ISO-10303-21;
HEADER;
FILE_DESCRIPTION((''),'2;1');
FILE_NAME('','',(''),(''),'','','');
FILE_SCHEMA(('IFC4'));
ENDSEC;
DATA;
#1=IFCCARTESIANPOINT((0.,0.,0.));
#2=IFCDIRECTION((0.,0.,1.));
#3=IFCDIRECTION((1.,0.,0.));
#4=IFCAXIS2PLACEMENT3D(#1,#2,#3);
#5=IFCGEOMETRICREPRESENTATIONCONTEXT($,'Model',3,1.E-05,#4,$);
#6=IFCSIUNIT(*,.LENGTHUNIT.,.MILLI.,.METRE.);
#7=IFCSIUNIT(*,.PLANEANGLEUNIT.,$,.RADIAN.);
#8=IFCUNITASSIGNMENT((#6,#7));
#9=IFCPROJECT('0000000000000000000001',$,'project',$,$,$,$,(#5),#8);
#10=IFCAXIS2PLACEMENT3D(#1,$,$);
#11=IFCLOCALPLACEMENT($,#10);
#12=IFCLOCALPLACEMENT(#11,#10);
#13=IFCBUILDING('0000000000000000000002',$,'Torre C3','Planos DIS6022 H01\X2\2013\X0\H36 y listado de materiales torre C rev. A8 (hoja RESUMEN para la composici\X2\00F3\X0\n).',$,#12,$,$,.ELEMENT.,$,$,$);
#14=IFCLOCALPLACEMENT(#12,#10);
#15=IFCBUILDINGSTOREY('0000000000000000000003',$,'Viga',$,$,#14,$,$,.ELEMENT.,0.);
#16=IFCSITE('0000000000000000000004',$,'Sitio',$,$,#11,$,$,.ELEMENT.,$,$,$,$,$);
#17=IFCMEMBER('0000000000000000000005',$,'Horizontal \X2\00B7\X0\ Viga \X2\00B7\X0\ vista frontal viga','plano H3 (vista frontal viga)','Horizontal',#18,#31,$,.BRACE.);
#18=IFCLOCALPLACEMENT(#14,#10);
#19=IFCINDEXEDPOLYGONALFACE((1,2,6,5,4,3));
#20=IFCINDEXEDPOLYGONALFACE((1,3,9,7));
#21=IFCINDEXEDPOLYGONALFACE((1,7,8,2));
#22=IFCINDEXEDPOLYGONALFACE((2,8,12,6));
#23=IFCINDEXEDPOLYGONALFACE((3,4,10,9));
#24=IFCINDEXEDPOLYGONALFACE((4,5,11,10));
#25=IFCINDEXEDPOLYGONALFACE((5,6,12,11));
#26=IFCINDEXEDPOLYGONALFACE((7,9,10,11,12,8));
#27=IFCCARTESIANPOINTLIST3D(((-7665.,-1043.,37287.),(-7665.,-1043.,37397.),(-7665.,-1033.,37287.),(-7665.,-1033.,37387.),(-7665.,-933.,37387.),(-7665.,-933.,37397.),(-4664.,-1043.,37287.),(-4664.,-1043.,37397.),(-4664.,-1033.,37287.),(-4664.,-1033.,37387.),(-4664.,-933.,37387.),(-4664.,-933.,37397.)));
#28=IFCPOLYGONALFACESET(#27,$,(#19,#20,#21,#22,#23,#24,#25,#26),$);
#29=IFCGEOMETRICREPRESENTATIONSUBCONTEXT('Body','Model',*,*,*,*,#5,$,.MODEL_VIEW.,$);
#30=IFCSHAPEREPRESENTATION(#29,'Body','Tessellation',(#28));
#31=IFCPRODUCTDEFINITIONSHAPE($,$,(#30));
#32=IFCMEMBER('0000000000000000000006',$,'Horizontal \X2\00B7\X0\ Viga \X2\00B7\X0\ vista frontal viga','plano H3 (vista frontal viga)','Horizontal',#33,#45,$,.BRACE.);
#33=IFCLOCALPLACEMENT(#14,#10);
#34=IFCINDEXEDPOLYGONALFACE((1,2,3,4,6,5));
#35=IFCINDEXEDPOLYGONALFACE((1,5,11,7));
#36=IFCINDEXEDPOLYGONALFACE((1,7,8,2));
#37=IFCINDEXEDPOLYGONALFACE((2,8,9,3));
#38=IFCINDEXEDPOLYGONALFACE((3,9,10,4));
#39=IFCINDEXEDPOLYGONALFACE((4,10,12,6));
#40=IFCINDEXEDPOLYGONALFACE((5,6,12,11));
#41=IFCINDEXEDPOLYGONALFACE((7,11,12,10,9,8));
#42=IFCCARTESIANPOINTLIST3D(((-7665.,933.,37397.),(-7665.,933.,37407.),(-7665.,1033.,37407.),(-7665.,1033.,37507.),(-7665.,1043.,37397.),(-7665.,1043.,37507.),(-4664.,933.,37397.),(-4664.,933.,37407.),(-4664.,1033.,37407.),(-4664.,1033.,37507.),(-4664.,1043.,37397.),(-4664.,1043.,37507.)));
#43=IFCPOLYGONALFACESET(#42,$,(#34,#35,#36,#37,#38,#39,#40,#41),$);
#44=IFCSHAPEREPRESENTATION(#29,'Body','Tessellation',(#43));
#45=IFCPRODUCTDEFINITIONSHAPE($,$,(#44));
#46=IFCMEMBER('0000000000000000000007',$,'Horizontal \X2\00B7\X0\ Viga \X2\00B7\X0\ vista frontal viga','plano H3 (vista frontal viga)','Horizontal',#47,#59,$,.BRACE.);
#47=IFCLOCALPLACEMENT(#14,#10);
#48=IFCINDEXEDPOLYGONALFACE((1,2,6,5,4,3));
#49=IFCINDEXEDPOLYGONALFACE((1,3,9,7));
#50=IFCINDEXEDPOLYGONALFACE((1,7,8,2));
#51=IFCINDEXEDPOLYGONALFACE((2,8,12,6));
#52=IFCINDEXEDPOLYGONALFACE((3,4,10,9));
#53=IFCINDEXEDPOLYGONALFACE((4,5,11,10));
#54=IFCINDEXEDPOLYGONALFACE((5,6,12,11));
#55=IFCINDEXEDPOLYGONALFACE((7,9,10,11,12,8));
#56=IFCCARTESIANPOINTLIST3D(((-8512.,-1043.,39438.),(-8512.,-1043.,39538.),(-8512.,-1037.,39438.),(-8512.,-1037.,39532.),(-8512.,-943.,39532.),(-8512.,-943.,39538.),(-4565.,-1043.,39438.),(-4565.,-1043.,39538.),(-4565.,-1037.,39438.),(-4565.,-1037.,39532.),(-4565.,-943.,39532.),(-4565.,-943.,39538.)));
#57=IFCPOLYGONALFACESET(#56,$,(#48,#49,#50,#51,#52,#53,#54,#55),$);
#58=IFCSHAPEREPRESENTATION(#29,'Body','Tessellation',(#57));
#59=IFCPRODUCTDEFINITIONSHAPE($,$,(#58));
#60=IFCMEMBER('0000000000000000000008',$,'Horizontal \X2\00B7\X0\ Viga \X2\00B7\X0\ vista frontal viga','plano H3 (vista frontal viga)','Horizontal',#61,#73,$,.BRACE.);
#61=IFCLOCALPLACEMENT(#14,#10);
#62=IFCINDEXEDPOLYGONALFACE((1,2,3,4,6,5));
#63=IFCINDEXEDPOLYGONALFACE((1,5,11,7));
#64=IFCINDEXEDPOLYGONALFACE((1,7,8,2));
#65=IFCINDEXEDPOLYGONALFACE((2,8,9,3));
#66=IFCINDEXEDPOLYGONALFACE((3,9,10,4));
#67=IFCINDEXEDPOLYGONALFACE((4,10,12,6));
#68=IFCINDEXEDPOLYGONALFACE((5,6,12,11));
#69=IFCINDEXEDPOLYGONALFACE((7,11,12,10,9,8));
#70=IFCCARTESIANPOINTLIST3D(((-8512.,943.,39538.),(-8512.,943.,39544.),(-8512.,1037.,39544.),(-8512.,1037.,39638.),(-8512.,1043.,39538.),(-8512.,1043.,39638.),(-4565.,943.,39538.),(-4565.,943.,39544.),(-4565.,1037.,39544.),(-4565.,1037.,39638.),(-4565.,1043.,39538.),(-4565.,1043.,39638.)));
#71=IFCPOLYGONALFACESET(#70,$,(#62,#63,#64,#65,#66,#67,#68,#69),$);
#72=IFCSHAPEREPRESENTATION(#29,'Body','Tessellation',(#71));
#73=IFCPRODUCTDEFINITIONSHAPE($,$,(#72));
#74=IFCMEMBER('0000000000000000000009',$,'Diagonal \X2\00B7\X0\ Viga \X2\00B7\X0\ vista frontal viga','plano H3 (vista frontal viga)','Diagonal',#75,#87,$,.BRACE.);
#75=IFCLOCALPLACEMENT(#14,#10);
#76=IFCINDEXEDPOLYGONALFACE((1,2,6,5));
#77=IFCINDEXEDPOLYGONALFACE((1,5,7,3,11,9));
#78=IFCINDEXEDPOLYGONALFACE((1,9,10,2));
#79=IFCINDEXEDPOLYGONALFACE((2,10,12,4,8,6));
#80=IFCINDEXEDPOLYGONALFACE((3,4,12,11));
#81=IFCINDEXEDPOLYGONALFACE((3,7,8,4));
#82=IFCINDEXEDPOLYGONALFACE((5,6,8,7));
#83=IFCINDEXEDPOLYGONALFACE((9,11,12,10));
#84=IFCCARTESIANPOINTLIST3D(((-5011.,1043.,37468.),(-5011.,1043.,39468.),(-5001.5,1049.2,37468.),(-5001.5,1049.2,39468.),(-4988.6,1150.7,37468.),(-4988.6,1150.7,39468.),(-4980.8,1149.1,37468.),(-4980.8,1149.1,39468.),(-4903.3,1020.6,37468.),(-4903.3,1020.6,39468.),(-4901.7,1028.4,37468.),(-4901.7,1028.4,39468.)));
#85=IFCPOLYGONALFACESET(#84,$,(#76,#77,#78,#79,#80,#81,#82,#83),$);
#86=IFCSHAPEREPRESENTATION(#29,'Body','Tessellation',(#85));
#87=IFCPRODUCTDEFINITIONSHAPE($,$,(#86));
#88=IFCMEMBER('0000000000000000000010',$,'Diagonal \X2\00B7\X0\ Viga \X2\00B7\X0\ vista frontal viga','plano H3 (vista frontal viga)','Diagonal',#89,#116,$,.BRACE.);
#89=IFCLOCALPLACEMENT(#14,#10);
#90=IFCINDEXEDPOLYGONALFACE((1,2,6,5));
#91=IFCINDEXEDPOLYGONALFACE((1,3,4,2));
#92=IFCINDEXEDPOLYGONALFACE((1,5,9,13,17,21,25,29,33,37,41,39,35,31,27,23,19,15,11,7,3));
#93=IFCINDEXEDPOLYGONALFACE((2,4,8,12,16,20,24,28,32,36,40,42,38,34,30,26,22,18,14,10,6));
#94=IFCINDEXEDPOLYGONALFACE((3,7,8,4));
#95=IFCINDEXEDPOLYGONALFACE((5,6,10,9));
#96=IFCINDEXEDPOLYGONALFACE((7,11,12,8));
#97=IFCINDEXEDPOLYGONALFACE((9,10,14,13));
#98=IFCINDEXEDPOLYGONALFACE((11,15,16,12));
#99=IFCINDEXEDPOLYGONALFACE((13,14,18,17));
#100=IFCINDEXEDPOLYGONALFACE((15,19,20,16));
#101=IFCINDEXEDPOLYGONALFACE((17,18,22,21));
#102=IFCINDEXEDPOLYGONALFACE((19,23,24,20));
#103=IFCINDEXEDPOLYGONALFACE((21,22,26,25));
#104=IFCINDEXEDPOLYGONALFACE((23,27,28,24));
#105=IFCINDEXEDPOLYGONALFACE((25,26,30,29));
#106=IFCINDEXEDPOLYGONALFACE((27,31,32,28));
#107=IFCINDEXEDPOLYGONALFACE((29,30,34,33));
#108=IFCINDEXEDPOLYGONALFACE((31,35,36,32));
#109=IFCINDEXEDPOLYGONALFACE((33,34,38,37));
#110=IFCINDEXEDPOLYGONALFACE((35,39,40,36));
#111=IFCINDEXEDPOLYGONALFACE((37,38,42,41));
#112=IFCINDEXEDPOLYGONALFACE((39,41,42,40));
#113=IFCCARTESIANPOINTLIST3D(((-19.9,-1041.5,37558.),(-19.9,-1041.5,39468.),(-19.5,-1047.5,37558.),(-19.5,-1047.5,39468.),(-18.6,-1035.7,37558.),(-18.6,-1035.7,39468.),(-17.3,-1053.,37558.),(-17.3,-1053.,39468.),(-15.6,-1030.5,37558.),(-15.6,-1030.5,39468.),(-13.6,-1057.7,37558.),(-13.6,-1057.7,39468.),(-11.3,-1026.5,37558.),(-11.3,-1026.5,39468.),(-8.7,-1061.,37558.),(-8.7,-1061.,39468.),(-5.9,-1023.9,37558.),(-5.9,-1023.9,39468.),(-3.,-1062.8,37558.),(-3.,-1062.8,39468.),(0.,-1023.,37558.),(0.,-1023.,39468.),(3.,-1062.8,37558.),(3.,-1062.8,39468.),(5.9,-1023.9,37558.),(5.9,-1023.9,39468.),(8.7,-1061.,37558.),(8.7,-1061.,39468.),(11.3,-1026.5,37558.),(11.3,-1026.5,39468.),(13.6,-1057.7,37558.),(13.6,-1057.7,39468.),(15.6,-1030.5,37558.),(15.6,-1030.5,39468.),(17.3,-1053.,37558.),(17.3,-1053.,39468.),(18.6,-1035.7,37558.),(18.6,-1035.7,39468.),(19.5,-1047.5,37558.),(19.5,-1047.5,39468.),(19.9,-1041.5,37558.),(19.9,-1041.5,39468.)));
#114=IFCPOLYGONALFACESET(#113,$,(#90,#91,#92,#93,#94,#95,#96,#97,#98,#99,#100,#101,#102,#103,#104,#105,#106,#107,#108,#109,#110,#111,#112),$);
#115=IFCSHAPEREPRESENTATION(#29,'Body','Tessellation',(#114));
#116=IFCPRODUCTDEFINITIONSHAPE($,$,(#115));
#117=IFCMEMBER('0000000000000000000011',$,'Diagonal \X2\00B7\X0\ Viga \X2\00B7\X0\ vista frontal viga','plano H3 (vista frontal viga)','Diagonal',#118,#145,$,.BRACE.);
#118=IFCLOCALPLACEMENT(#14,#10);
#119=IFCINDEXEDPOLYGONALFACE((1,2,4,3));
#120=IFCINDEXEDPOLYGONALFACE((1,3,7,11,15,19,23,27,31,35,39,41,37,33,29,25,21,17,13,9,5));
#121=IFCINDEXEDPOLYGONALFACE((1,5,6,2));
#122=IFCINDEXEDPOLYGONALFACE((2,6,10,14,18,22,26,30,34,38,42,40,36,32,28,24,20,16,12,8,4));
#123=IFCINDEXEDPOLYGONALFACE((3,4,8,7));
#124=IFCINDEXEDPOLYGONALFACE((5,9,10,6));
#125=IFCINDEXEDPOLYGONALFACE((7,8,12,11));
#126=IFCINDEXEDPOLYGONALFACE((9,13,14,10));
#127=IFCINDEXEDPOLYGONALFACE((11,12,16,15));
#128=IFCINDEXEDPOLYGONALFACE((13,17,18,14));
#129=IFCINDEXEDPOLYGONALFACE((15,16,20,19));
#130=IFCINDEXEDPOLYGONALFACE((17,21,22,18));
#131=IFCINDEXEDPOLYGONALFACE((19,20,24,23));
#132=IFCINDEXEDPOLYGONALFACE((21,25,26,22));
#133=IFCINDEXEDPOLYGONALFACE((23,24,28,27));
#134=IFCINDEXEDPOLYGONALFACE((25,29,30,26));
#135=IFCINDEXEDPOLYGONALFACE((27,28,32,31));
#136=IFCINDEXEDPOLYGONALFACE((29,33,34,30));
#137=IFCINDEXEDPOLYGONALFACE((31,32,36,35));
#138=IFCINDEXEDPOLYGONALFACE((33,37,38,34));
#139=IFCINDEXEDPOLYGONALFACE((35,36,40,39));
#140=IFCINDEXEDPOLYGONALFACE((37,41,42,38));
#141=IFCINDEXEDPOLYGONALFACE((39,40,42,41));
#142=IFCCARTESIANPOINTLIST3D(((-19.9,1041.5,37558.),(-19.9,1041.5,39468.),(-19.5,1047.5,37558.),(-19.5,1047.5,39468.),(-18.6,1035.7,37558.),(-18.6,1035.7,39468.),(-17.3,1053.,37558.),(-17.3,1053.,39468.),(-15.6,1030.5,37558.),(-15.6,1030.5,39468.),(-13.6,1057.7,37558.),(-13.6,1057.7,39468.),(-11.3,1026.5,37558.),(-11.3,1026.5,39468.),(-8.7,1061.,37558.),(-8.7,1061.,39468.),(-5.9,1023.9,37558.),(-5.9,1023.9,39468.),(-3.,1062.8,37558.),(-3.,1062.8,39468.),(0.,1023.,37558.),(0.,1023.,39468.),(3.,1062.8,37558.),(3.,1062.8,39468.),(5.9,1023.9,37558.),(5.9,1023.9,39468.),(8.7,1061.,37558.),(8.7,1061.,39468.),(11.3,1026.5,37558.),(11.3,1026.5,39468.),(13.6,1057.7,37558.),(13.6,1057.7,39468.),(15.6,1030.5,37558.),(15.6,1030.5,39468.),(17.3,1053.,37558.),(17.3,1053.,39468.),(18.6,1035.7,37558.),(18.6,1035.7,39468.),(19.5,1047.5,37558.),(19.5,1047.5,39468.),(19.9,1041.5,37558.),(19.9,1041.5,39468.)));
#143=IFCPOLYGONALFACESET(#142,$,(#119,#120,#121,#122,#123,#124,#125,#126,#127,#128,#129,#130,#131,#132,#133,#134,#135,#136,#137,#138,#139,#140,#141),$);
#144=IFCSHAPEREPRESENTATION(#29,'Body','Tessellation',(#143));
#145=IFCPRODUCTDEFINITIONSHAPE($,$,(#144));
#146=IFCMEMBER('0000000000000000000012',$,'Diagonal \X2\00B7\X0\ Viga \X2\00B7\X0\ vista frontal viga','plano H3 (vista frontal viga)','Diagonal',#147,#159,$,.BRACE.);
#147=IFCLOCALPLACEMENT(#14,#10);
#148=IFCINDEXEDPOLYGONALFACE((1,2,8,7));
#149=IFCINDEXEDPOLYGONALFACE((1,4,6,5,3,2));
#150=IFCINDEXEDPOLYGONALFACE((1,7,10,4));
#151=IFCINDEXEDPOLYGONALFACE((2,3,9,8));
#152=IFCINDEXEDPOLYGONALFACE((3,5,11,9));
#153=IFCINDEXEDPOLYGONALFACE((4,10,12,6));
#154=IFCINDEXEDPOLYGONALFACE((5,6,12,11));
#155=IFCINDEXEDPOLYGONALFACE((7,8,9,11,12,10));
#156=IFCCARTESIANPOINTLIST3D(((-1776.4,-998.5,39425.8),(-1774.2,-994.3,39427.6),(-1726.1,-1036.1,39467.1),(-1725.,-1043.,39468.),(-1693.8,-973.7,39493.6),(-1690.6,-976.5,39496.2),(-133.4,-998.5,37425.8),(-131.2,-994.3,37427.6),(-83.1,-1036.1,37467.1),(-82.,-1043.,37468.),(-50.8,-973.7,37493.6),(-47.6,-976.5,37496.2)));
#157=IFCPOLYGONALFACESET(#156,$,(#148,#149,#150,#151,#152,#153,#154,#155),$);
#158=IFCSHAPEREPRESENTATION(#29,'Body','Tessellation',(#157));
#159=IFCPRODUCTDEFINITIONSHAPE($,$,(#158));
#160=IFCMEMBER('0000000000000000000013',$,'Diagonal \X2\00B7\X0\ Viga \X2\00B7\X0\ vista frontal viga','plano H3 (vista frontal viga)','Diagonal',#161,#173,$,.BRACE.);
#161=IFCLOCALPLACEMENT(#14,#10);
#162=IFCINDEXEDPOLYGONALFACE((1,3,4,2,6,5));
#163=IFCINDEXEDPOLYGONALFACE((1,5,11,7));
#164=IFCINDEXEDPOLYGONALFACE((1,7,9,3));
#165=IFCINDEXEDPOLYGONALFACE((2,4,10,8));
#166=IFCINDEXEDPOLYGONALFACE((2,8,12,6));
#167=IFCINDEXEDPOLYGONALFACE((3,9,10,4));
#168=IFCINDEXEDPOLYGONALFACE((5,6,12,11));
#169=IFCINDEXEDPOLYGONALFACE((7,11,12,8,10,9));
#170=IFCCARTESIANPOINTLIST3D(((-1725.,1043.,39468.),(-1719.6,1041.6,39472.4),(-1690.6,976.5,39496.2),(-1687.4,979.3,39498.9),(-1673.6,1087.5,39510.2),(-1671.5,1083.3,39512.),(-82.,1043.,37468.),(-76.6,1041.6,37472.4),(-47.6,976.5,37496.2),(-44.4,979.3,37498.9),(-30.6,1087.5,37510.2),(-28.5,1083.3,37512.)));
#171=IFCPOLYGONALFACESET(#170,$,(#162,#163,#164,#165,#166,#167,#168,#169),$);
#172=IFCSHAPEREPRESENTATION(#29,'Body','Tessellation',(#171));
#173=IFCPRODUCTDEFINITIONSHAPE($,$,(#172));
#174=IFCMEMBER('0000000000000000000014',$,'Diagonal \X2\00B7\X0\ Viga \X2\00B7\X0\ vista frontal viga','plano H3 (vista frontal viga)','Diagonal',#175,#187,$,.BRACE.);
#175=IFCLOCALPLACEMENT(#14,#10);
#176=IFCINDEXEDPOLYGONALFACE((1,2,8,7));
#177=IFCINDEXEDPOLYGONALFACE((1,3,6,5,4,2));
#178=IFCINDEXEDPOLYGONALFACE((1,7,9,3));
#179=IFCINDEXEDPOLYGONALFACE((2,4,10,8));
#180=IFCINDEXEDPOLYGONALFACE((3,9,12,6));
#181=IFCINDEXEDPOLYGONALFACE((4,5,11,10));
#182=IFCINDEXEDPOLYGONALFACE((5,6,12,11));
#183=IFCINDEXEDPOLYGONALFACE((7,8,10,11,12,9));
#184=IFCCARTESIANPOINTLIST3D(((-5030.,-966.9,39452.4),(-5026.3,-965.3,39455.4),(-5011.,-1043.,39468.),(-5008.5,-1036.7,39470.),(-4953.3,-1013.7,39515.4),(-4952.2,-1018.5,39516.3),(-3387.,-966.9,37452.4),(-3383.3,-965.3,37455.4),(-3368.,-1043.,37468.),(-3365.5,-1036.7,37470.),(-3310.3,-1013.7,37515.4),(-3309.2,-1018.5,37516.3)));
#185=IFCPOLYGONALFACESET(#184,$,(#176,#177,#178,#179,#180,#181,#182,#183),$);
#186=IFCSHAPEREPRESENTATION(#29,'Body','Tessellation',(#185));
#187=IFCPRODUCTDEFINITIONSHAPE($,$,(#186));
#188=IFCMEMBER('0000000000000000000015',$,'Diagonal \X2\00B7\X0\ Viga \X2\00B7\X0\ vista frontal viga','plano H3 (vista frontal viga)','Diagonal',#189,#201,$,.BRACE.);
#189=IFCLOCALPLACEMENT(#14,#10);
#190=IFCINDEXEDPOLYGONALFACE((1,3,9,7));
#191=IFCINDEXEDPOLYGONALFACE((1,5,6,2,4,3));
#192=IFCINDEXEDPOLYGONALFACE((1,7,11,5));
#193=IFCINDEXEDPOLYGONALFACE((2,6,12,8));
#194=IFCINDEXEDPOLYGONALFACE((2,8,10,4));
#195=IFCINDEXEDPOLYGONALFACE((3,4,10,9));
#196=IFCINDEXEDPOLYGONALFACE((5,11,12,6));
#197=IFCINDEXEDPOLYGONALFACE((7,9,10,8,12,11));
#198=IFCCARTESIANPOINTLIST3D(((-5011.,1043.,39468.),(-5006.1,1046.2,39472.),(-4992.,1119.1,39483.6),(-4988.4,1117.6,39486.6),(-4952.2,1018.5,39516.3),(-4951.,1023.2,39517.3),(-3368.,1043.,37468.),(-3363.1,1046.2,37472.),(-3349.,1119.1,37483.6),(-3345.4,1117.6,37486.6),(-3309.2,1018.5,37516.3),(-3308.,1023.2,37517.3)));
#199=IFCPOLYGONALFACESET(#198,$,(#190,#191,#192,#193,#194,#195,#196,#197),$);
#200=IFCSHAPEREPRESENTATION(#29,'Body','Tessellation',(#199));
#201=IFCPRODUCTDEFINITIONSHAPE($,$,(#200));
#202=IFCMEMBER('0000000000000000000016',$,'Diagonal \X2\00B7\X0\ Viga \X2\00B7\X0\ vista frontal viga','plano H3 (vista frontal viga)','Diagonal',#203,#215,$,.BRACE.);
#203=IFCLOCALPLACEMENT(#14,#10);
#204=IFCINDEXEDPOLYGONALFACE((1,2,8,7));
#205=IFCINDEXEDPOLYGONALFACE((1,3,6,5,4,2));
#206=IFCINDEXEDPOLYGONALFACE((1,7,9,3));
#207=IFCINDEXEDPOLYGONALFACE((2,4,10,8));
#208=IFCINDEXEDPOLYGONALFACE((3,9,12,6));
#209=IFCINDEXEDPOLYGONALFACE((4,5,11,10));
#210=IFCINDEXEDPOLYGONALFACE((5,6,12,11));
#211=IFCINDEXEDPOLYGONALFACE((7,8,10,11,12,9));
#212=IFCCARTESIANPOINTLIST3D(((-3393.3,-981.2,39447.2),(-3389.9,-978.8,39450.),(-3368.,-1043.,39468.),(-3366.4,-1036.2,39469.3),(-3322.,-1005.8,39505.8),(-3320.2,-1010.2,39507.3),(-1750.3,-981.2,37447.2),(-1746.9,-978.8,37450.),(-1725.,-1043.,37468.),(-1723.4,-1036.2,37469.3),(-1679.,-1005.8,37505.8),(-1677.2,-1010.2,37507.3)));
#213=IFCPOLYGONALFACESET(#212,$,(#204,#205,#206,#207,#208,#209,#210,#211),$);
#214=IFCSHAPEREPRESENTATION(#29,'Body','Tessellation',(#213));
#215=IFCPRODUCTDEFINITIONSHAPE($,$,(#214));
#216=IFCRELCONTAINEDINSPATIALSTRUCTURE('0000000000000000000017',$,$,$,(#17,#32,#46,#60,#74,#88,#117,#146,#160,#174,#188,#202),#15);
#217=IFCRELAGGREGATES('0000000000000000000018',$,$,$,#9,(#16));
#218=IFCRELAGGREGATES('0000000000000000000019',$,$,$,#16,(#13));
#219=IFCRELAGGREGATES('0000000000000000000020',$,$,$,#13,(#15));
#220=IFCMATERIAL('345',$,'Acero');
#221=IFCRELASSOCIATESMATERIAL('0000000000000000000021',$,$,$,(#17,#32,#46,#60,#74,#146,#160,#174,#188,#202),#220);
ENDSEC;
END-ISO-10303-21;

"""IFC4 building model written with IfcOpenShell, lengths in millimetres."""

from ifc_helpers import new_model, si_unit, frame, frame_2d, origin, origin_with_axes, place, context, subcontext, project, spatial, circle, l_section, extrude, material, element, save


model = new_model("IFC4")

# Units and contexts
model_context = context("Model", 3, precision=1e-05, world=origin_with_axes())
body_context = subcontext(model_context, "Body", "Model", "MODEL_VIEW")
ifc_project = project(units=[si_unit("LENGTHUNIT", "METRE", prefix="MILLI"), si_unit("PLANEANGLEUNIT", "RADIAN")], contexts=[model_context])

# Site, building, storey
site_placement = place(None, origin())
site = spatial("IfcSite", under=ifc_project, at=site_placement, Name="Sitio", CompositionType="ELEMENT")
building_placement = place(site_placement, origin())
building = spatial("IfcBuilding", under=site, at=building_placement, Name="Torre C3", Description="Planos DIS6022 H01–H36 y listado de materiales torre C rev. A8 (hoja RESUMEN para la composición).", CompositionType="ELEMENT")
storey_placement = place(building_placement, origin())
storey = spatial("IfcBuildingStorey", under=building, at=storey_placement, Name="Viga", CompositionType="ELEMENT", Elevation=0.0)

# Members
ifc_material_1 = material(Name="345", Category="Acero")
for number, where, z_axis, x_axis, name in (
    (1, (-4664.0, -1043.0, 37397.0), (-1.0, 0.0, 0.0), (0.0, 1.0, 0.0), "Horizontal · Viga · vista frontal viga"),
    (2, (-4664.0, 1043.0, 37397.0), (-1.0, 0.0, 0.0), (0.0, -1.0, 0.0), "Horizontal · Viga · vista frontal viga"),
):
    element("IfcMember", number, at=place(storey_placement, frame(where, z_axis=z_axis, x_axis=x_axis)), inside=storey, material=ifc_material_1, Name=name, Description="plano H3 (vista frontal viga)", ObjectType="Horizontal", PredefinedType="BRACE", context=body_context, shape_type="SweptSolid", body=[
        extrude(l_section(Depth=110.0, Width=110.0, Thickness=10.0, at=frame_2d((55.0, 55.0))), None, (0.0, 0.0, 1.0), 3001.0),
    ])
for number, where, z_axis, x_axis, name in (
    (3, (-4565.0, -1043.0, 39538.0), (-1.0, 0.0, 0.0), (0.0, 1.0, 0.0), "Horizontal · Viga · vista frontal viga"),
    (4, (-4565.0, 1043.0, 39538.0), (-1.0, 0.0, 0.0), (0.0, -1.0, 0.0), "Horizontal · Viga · vista frontal viga"),
):
    element("IfcMember", number, at=place(storey_placement, frame(where, z_axis=z_axis, x_axis=x_axis)), inside=storey, material=ifc_material_1, Name=name, Description="plano H3 (vista frontal viga)", ObjectType="Horizontal", PredefinedType="BRACE", context=body_context, shape_type="SweptSolid", body=[
        extrude(l_section(Depth=100.0, Width=100.0, Thickness=6.0, at=frame_2d((50.0, 50.0))), None, (0.0, 0.0, 1.0), 3947.0),
    ])
member_1_placement = place(storey_placement, frame((-5011.0, 1043.0, 37468.0), z_axis=(0.0, 0.0, 1.0), x_axis=(0.979018, -0.203775, 0.0)))
element("IfcMember", 5, at=member_1_placement, inside=storey, material=ifc_material_1, Name="Diagonal · Viga · vista frontal viga", Description="plano H3 (vista frontal viga)", ObjectType="Diagonal", PredefinedType="BRACE", context=body_context, shape_type="SweptSolid", body=[
    extrude(l_section(Depth=110.0, Width=110.0, Thickness=8.0, at=frame_2d((55.0, 55.0))), None, (0.0, 0.0, 1.0), 2000.0),
])
for number, where, z_axis, x_axis, name in (
    (6, (0.0, -1043.0, 37558.0), (0.0, 0.0, 1.0), (0.0, 1.0, 0.0), "Diagonal · Viga · vista frontal viga"),
    (7, (0.0, 1043.0, 37558.0), (0.0, 0.0, 1.0), (0.0, -1.0, 0.0), "Diagonal · Viga · vista frontal viga"),
):
    element("IfcMember", number, at=place(storey_placement, frame(where, z_axis=z_axis, x_axis=x_axis)), inside=storey, Name=name, Description="plano H3 (vista frontal viga)", ObjectType="Diagonal", PredefinedType="BRACE", context=body_context, shape_type="SweptSolid", body=[
        extrude(circle(Radius=20.0), None, (0.0, 0.0, 1.0), 1910.0),
    ])
for number, where, z_axis, x_axis, name in (
    (8, (-82.0, -1043.0, 37468.0), (-0.634772, 0.0, 0.772699), (0.429809, 0.831019, 0.353088), "Diagonal · Viga · vista frontal viga"),
    (9, (-82.0, 1043.0, 37468.0), (-0.634772, 0.0, 0.772699), (0.429809, -0.831019, 0.353088), "Diagonal · Viga · vista frontal viga"),
    (10, (-3368.0, -1043.0, 37468.0), (-0.634772, 0.0, 0.772699), (0.735468, 0.306666, 0.604187), "Diagonal · Viga · vista frontal viga"),
    (11, (-3368.0, 1043.0, 37468.0), (-0.634772, 0.0, 0.772699), (0.735468, -0.306666, 0.604187), "Diagonal · Viga · vista frontal viga"),
):
    element("IfcMember", number, at=place(storey_placement, frame(where, z_axis=z_axis, x_axis=x_axis)), inside=storey, material=ifc_material_1, Name=name, Description="plano H3 (vista frontal viga)", ObjectType="Diagonal", PredefinedType="BRACE", context=body_context, shape_type="SweptSolid", body=[
        extrude(l_section(Depth=80.0, Width=80.0, Thickness=5.0, at=frame_2d((40.0, 40.0))), None, (0.0, 0.0, 1.0), 2588.3),
    ])
for number, where, z_axis, x_axis, name in (
    (12, (-1725.0, -1043.0, 37468.0), (-0.634772, 0.0, 0.772699), (0.682717, 0.468339, 0.560852), "Diagonal · Viga · vista frontal viga"),
):
    element("IfcMember", number, at=place(storey_placement, frame(where, z_axis=z_axis, x_axis=x_axis)), inside=storey, material=ifc_material_1, Name=name, Description="plano H3 (vista frontal viga)", ObjectType="Diagonal", PredefinedType="BRACE", context=body_context, shape_type="SweptSolid", body=[
        extrude(l_section(Depth=70.0, Width=70.0, Thickness=5.0, at=frame_2d((35.0, 35.0))), None, (0.0, 0.0, 1.0), 2588.3),
    ])

save(model, "model.ifc")
